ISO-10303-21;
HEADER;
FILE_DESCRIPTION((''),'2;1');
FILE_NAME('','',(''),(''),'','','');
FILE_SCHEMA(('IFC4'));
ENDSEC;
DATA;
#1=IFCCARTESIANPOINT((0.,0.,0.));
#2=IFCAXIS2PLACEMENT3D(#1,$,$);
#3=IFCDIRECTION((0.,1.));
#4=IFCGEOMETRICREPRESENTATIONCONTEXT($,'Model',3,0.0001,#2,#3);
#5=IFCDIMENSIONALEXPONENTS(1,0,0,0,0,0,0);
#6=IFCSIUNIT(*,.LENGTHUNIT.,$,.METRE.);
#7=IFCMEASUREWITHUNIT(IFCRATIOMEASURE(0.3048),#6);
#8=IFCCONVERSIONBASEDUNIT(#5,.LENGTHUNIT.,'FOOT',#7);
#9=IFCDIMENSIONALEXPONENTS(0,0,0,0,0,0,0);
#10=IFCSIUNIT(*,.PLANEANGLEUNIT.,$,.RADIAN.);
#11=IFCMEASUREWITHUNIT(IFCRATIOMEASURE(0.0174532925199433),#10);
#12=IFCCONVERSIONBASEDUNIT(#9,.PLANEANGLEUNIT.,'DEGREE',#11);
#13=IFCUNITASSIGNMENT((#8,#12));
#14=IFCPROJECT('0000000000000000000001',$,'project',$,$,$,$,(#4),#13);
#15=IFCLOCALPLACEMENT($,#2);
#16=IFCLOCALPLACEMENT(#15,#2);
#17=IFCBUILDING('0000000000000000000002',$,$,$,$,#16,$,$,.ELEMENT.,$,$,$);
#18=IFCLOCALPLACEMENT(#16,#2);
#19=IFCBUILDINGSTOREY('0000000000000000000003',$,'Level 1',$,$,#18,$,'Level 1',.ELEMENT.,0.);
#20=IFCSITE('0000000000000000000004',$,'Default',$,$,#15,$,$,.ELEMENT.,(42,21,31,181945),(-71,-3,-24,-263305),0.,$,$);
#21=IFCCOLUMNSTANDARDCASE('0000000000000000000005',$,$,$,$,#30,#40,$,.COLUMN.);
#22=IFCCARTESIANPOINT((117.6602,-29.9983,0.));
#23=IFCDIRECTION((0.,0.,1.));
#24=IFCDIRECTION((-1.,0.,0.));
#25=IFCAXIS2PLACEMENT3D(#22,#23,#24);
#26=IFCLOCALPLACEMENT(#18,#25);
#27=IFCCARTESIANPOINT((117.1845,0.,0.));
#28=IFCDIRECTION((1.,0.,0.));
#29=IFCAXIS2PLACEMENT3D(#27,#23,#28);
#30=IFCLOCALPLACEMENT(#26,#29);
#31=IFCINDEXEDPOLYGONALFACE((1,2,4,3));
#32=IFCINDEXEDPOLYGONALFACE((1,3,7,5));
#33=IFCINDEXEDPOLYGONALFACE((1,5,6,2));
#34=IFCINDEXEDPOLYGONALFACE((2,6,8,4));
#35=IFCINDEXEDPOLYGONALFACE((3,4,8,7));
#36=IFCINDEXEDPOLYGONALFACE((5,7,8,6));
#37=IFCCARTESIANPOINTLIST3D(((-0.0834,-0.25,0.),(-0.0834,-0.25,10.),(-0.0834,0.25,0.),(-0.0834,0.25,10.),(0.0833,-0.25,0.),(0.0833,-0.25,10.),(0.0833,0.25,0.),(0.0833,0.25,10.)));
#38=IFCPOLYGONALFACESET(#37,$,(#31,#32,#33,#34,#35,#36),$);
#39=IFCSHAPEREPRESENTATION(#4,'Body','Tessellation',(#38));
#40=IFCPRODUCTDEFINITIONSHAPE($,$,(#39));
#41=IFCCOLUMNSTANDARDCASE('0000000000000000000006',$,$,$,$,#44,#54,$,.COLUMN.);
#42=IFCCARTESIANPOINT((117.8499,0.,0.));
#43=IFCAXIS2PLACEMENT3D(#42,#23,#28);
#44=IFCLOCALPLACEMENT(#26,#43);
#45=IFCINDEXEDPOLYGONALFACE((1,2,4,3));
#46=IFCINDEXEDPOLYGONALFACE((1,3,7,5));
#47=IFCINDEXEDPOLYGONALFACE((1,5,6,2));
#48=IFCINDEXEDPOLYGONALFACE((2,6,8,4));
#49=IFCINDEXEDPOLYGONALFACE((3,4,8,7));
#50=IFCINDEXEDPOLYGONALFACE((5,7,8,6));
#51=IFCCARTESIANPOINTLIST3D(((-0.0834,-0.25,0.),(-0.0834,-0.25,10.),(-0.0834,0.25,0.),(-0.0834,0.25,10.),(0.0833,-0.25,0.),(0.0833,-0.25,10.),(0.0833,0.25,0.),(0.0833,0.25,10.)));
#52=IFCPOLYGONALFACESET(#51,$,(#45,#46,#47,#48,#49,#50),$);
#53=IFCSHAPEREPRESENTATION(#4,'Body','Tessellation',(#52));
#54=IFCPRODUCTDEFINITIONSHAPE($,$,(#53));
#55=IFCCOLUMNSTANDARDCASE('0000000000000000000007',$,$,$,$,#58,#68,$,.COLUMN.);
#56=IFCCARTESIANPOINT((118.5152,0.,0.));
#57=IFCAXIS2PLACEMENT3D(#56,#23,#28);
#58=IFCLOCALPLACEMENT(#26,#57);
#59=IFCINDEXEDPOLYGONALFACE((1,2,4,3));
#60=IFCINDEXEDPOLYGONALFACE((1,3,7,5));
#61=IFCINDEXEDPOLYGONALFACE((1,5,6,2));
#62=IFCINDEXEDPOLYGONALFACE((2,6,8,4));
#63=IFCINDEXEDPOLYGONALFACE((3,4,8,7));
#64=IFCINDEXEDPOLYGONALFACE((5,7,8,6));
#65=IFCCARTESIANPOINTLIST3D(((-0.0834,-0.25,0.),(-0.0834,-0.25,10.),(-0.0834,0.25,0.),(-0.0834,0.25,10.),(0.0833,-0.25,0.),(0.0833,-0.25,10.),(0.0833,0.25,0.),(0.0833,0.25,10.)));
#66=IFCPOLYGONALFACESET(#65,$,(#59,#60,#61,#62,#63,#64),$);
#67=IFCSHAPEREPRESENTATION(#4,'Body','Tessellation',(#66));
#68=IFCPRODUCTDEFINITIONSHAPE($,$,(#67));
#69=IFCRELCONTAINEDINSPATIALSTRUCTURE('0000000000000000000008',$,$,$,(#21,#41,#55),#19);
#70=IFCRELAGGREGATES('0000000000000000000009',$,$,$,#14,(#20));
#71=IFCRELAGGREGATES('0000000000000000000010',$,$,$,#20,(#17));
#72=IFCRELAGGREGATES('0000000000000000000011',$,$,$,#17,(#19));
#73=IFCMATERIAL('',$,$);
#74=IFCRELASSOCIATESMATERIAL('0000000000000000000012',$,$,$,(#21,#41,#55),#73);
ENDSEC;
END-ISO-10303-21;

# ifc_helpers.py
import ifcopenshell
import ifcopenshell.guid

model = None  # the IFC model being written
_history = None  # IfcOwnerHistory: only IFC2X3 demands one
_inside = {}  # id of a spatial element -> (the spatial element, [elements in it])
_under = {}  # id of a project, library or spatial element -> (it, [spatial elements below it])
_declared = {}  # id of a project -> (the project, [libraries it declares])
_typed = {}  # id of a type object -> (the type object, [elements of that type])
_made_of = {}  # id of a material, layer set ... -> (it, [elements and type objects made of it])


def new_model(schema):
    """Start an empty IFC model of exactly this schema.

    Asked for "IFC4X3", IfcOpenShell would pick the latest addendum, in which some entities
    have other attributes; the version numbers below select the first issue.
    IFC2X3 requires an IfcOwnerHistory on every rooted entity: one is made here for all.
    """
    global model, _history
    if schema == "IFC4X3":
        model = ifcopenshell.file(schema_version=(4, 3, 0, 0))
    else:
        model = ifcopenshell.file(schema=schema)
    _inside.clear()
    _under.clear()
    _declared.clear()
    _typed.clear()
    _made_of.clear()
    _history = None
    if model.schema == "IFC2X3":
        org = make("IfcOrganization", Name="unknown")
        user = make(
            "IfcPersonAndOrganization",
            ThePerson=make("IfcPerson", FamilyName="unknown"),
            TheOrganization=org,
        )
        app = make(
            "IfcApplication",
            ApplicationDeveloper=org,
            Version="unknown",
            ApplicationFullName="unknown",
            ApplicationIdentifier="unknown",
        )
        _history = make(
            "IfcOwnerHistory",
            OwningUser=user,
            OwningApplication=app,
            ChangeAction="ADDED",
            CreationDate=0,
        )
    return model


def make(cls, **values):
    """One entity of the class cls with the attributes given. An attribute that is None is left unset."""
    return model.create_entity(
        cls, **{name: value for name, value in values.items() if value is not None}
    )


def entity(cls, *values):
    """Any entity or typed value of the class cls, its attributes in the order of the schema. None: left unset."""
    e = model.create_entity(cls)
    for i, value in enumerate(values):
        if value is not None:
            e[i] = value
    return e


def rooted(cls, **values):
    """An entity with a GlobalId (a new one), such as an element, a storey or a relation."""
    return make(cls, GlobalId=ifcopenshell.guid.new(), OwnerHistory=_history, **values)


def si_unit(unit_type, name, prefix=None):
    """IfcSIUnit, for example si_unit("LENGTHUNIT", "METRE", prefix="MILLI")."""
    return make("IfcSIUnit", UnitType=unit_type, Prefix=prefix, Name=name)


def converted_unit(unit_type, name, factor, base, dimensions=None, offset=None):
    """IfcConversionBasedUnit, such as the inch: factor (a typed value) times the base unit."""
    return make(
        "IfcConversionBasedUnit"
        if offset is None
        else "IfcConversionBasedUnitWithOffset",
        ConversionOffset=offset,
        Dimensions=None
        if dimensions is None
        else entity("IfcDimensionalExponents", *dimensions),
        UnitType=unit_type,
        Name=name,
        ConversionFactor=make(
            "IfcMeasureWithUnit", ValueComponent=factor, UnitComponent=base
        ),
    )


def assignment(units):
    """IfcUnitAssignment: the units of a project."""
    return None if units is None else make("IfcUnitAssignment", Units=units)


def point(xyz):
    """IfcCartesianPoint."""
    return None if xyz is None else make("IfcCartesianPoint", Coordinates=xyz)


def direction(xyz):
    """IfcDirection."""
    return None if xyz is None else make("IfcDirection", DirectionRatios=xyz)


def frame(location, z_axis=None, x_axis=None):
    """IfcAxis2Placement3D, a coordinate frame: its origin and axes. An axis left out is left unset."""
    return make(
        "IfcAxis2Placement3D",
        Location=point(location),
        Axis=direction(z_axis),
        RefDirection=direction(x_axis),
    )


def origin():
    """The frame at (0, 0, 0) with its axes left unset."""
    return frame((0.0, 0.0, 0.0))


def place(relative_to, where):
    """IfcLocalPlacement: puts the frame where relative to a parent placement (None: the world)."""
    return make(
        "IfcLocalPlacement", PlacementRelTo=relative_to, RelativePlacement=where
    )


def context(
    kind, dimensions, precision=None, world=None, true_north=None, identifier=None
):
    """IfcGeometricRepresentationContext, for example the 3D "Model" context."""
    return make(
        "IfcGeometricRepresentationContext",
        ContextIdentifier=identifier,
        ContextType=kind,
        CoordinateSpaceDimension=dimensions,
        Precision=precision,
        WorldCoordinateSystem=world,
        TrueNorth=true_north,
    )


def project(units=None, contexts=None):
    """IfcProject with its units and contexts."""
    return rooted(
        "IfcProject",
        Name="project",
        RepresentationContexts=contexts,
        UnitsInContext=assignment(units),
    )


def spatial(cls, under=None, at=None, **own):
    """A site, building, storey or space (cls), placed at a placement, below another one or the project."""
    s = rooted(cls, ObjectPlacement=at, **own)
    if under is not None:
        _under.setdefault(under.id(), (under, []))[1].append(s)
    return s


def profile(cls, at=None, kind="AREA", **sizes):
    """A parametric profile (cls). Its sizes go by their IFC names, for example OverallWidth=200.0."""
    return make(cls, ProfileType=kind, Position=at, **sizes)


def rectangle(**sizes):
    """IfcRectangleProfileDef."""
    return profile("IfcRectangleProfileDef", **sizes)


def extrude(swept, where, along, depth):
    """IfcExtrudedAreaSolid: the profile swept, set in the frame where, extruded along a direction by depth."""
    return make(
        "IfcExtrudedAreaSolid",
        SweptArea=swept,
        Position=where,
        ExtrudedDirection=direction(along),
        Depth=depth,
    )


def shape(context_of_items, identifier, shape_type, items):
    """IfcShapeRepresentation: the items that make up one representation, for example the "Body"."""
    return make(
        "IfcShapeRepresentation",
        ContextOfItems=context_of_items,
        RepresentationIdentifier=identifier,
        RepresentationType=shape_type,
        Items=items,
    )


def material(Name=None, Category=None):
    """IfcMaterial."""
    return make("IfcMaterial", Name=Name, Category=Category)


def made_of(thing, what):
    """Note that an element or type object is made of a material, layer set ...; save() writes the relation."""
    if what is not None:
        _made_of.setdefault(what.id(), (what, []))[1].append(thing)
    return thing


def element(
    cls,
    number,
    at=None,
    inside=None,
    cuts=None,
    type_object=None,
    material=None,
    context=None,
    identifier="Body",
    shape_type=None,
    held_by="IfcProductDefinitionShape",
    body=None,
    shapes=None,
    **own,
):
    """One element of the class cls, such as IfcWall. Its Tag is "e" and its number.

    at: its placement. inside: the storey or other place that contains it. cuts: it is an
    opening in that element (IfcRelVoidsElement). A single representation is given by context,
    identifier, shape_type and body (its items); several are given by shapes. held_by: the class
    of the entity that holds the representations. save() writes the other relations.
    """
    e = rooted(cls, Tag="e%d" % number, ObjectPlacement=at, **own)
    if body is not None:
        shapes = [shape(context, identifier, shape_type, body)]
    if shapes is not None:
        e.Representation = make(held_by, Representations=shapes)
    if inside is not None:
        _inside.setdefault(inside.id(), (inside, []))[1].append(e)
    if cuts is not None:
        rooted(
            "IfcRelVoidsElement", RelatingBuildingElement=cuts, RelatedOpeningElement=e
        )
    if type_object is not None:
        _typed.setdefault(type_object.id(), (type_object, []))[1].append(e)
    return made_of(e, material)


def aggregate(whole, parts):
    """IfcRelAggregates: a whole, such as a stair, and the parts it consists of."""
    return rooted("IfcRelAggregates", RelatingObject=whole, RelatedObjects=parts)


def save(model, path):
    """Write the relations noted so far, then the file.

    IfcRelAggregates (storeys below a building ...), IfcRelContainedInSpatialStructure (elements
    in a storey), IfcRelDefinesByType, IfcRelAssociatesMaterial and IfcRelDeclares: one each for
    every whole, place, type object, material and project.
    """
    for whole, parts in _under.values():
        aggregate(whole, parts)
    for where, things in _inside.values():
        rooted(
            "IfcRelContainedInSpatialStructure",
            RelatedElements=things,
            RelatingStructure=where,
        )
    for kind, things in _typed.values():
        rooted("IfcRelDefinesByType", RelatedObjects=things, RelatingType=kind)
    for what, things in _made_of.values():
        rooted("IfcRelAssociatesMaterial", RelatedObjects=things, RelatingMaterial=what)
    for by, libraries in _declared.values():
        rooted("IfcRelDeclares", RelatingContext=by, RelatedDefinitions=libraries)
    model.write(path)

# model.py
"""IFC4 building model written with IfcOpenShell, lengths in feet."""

from ifc_helpers import new_model, entity, si_unit, converted_unit, direction, frame, origin, place, context, project, spatial, rectangle, extrude, material, element, save


model = new_model("IFC4")

# Units and contexts
model_context = context("Model", 3, precision=0.0001, world=origin(), true_north=direction((0.0, 1.0)))
ifc_project = project(units=[converted_unit("LENGTHUNIT", "FOOT", entity("IfcRatioMeasure", 0.3048), si_unit("LENGTHUNIT", "METRE"), dimensions=[1, 0, 0, 0, 0, 0, 0]), converted_unit("PLANEANGLEUNIT", "DEGREE", entity("IfcRatioMeasure", 0.0174532925199433), si_unit("PLANEANGLEUNIT", "RADIAN"), dimensions=[0, 0, 0, 0, 0, 0, 0])], contexts=[model_context])

# Site, building, storey
site_placement = place(None, origin())
site = spatial("IfcSite", under=ifc_project, at=site_placement, Name="Default", CompositionType="ELEMENT", RefLatitude=(42, 21, 31, 181945), RefLongitude=(-71, -3, -24, -263305), RefElevation=0.0)
building_placement = place(site_placement, origin())
building = spatial("IfcBuilding", under=site, at=building_placement, CompositionType="ELEMENT")
storey_placement = place(building_placement, origin())
storey = spatial("IfcBuildingStorey", under=building, at=storey_placement, Name="Level 1", LongName="Level 1", CompositionType="ELEMENT", Elevation=0.0)

# Columns
ifc_material = material(Name="")
placement = place(storey_placement, frame((117.6602, -29.9983, 0.0), z_axis=(0.0, 0.0, 1.0), x_axis=(-1.0, 0.0, 0.0)))
for number, where, z_axis, x_axis in (
    (1, (117.1845, 0.0, 0.0), (0.0, 0.0, 1.0), (1.0, 0.0, 0.0)),
    (2, (117.8499, 0.0, 0.0), (0.0, 0.0, 1.0), (1.0, 0.0, 0.0)),
    (3, (118.5152, 0.0, 0.0), (0.0, 0.0, 1.0), (1.0, 0.0, 0.0)),
):
    element("IfcColumnStandardCase", number, at=place(placement, frame(where, z_axis=z_axis, x_axis=x_axis)), inside=storey, material=ifc_material, PredefinedType="COLUMN", context=model_context, shape_type="SweptSolid", body=[
        extrude(rectangle(XDim=0.1667, YDim=0.5), origin(), (0.0, 0.0, 1.0), 10.0),
    ])

save(model, "model.ifc")
